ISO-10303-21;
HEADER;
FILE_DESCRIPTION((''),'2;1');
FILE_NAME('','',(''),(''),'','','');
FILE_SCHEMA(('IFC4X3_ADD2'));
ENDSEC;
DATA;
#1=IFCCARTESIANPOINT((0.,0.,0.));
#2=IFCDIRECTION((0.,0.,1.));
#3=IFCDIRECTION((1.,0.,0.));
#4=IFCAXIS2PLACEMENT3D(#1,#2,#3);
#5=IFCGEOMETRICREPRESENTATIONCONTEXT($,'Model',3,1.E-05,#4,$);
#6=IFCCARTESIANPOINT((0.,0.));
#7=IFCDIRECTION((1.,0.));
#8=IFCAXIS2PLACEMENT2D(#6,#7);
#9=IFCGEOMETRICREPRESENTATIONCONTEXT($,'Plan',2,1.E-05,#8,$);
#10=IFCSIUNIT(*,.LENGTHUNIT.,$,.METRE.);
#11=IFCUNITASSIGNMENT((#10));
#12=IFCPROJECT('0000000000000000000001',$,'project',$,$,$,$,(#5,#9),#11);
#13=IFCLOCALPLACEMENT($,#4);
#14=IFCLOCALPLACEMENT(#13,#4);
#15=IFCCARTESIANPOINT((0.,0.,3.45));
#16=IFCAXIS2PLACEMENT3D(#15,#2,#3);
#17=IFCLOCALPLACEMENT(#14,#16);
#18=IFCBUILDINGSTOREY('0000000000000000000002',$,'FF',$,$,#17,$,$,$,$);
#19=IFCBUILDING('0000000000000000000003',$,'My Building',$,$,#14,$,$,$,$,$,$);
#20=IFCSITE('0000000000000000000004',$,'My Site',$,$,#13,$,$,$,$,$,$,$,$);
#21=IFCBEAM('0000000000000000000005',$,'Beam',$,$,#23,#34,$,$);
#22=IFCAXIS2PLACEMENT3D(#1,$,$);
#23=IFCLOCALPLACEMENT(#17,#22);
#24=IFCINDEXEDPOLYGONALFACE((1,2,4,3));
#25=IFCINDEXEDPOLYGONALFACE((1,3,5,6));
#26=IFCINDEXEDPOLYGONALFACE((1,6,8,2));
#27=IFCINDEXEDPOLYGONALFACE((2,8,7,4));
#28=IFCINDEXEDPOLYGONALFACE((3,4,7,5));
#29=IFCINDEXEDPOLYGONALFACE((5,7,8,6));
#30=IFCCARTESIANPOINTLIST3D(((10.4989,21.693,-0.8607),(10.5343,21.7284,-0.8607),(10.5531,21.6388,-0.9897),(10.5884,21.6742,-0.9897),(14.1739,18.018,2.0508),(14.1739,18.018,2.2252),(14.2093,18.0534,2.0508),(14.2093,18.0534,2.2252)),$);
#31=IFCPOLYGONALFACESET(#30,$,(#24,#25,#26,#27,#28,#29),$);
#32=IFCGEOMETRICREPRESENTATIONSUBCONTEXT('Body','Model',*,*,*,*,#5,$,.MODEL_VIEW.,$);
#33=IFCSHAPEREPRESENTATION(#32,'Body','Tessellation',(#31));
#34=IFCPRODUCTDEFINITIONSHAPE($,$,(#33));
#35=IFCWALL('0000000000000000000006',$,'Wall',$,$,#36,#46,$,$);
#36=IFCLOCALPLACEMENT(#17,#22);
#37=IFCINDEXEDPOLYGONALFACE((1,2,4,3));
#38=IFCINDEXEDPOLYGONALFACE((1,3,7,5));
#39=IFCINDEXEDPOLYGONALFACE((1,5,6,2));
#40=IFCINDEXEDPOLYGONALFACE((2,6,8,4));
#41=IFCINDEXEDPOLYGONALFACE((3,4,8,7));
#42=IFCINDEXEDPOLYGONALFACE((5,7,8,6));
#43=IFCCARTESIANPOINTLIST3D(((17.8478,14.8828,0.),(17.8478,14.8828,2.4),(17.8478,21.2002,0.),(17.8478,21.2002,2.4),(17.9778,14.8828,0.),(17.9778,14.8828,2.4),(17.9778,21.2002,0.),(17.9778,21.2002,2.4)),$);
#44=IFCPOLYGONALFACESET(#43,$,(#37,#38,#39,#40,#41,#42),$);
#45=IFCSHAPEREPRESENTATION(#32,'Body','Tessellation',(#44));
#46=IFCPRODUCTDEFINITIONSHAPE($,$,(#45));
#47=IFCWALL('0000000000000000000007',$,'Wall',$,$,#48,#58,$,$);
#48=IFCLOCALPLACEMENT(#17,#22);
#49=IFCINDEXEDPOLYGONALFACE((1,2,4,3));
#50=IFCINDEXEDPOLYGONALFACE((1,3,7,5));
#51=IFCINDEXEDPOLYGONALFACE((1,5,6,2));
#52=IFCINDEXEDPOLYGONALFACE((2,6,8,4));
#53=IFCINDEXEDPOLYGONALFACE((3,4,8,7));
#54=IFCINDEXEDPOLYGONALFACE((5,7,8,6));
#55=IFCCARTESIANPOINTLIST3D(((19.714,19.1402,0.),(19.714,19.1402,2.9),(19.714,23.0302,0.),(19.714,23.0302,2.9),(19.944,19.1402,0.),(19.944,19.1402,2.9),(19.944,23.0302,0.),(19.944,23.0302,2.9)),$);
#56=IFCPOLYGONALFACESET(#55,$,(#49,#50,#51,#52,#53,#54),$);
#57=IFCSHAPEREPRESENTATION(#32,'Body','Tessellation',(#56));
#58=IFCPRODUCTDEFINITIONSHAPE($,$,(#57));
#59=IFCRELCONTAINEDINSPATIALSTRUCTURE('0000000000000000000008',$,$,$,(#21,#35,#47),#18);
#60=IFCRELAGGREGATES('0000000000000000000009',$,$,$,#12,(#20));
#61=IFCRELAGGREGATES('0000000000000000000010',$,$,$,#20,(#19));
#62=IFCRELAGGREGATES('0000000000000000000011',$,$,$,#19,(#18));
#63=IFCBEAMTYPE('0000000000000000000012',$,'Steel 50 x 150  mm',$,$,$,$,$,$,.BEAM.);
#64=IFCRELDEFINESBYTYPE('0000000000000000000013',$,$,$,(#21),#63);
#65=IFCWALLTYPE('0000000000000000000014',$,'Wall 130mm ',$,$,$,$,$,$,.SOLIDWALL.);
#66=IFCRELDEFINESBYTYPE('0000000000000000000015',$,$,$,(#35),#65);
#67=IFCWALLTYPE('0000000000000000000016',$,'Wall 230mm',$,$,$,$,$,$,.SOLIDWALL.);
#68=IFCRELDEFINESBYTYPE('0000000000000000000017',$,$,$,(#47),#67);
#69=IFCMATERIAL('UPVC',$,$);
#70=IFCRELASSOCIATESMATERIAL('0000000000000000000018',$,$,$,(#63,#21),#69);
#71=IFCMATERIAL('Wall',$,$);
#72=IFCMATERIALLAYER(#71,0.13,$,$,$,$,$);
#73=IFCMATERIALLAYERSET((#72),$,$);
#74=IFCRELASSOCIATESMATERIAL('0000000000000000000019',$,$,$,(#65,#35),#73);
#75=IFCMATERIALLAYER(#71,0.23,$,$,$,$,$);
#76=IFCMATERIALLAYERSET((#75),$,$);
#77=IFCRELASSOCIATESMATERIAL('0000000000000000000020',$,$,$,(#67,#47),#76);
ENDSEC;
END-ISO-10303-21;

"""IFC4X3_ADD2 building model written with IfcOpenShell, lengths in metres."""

from ifc_helpers import new_model, si_unit, frame, origin_with_axes, origin_2d_with_axis, place, context, subcontext, project, spatial, indexed_curve, rectangle, outline, extrude, clip, halfspace, material, layer, layer_set, layer_usage, material_profile, profile_set, profile_usage, type_object, element, save


model = new_model("IFC4X3_ADD2")

# Units and contexts
model_context = context("Model", 3, precision=1e-05, world=origin_with_axes())
plan_context = context("Plan", 2, precision=1e-05, world=origin_2d_with_axis())
body_context_1 = subcontext(model_context, "Body", "Model", "MODEL_VIEW")
ifc_project = project(units=[si_unit("LENGTHUNIT", "METRE")], contexts=[model_context, plan_context])

# Site, building, storey
site_placement = place(None, origin_with_axes())
site = spatial("IfcSite", under=ifc_project, at=site_placement, Name="My Site")
building_placement = place(site_placement, origin_with_axes())
building = spatial("IfcBuilding", under=site, at=building_placement, Name="My Building")
storey_placement = place(building_placement, frame((0.0, 0.0, 3.45), z_axis=(0.0, 0.0, 1.0), x_axis=(1.0, 0.0, 0.0)))
storey = spatial("IfcBuildingStorey", under=building, at=storey_placement, Name="FF")

# Beam
ifc_material_1 = material(Name="UPVC")
ifc_material_profile = material_profile(ifc_material_1, rectangle(XDim=0.05, YDim=0.15))
ifc_profile_set = profile_set([ifc_material_profile])
beam_type = type_object("IfcBeamType", Name="Steel 50 x 150  mm", PredefinedType="BEAM", material=ifc_profile_set)
ifc_profile_usage_1 = profile_usage(ifc_profile_set)
beam_1_placement = place(storey_placement, frame((10.5437, 21.6836, -0.9252), z_axis=(0.608007, -0.608008, 0.510543), x_axis=(0.707107, 0.707106, 0.0)))
element("IfcBeam", 1, at=beam_1_placement, inside=storey, type_object=beam_type, material=ifc_profile_usage_1, Name="Beam", context=body_context_1, shape_type="Clipping", body=[
    clip(extrude(rectangle(XDim=0.05, YDim=0.15), origin_with_axes(), (0.0, 0.0, 1.0), 6.1498), halfspace(frame((-5.1467, -2.6338, 4.4359), z_axis=(0.0, -0.510543, 0.859852), x_axis=(-1.0, 0.0, 0.0)), False)),
])

# Walls
ifc_material_2 = material(Name="Wall")
ifc_layer_1 = layer(ifc_material_2, 0.13)
ifc_layer_set_1 = layer_set([ifc_layer_1])
ifc_layer_usage_1 = layer_usage(ifc_layer_set_1, "AXIS2", "POSITIVE", 0.0)
wall_type_1 = type_object("IfcWallType", Name="Wall 130mm ", PredefinedType="SOLIDWALL", material=ifc_layer_set_1)
wall_1_placement = place(storey_placement, frame((17.9778, 14.8828, 0.0), z_axis=(0.0, 0.0, 1.0), x_axis=(0.000001, 1.0, 0.0)))
element("IfcWall", 2, at=wall_1_placement, inside=storey, type_object=wall_type_1, material=ifc_layer_usage_1, Name="Wall", context=body_context_1, shape_type="SweptSolid", body=[
    extrude(outline(indexed_curve([(0.0, 0.0), (0.0, 0.13), (6.3175, 0.13), (6.3175, 0.0), (0.0, 0.0)], self_intersect=False)), origin_with_axes(), (0.0, 0.0, 1.0), 2.4),
])
ifc_layer_2 = layer(ifc_material_2, 0.23)
ifc_layer_set_2 = layer_set([ifc_layer_2])
ifc_layer_usage_2 = layer_usage(ifc_layer_set_2, "AXIS2", "POSITIVE", 0.0)
wall_type_2 = type_object("IfcWallType", Name="Wall 230mm", PredefinedType="SOLIDWALL", material=ifc_layer_set_2)
wall_2_placement = place(storey_placement, frame((19.944, 19.1402, 0.0), z_axis=(0.0, 0.0, 1.0), x_axis=(0.000001, 1.0, 0.0)))
element("IfcWall", 3, at=wall_2_placement, inside=storey, type_object=wall_type_2, material=ifc_layer_usage_2, Name="Wall", context=body_context_1, shape_type="SweptSolid", body=[
    extrude(outline(indexed_curve([(0.0, 0.0), (0.0, 0.23), (3.89, 0.23), (3.89, 0.0), (0.0, 0.0)], self_intersect=False)), origin_with_axes(), (0.0, 0.0, 1.0), 2.9),
])

save(model, "model.ifc")
